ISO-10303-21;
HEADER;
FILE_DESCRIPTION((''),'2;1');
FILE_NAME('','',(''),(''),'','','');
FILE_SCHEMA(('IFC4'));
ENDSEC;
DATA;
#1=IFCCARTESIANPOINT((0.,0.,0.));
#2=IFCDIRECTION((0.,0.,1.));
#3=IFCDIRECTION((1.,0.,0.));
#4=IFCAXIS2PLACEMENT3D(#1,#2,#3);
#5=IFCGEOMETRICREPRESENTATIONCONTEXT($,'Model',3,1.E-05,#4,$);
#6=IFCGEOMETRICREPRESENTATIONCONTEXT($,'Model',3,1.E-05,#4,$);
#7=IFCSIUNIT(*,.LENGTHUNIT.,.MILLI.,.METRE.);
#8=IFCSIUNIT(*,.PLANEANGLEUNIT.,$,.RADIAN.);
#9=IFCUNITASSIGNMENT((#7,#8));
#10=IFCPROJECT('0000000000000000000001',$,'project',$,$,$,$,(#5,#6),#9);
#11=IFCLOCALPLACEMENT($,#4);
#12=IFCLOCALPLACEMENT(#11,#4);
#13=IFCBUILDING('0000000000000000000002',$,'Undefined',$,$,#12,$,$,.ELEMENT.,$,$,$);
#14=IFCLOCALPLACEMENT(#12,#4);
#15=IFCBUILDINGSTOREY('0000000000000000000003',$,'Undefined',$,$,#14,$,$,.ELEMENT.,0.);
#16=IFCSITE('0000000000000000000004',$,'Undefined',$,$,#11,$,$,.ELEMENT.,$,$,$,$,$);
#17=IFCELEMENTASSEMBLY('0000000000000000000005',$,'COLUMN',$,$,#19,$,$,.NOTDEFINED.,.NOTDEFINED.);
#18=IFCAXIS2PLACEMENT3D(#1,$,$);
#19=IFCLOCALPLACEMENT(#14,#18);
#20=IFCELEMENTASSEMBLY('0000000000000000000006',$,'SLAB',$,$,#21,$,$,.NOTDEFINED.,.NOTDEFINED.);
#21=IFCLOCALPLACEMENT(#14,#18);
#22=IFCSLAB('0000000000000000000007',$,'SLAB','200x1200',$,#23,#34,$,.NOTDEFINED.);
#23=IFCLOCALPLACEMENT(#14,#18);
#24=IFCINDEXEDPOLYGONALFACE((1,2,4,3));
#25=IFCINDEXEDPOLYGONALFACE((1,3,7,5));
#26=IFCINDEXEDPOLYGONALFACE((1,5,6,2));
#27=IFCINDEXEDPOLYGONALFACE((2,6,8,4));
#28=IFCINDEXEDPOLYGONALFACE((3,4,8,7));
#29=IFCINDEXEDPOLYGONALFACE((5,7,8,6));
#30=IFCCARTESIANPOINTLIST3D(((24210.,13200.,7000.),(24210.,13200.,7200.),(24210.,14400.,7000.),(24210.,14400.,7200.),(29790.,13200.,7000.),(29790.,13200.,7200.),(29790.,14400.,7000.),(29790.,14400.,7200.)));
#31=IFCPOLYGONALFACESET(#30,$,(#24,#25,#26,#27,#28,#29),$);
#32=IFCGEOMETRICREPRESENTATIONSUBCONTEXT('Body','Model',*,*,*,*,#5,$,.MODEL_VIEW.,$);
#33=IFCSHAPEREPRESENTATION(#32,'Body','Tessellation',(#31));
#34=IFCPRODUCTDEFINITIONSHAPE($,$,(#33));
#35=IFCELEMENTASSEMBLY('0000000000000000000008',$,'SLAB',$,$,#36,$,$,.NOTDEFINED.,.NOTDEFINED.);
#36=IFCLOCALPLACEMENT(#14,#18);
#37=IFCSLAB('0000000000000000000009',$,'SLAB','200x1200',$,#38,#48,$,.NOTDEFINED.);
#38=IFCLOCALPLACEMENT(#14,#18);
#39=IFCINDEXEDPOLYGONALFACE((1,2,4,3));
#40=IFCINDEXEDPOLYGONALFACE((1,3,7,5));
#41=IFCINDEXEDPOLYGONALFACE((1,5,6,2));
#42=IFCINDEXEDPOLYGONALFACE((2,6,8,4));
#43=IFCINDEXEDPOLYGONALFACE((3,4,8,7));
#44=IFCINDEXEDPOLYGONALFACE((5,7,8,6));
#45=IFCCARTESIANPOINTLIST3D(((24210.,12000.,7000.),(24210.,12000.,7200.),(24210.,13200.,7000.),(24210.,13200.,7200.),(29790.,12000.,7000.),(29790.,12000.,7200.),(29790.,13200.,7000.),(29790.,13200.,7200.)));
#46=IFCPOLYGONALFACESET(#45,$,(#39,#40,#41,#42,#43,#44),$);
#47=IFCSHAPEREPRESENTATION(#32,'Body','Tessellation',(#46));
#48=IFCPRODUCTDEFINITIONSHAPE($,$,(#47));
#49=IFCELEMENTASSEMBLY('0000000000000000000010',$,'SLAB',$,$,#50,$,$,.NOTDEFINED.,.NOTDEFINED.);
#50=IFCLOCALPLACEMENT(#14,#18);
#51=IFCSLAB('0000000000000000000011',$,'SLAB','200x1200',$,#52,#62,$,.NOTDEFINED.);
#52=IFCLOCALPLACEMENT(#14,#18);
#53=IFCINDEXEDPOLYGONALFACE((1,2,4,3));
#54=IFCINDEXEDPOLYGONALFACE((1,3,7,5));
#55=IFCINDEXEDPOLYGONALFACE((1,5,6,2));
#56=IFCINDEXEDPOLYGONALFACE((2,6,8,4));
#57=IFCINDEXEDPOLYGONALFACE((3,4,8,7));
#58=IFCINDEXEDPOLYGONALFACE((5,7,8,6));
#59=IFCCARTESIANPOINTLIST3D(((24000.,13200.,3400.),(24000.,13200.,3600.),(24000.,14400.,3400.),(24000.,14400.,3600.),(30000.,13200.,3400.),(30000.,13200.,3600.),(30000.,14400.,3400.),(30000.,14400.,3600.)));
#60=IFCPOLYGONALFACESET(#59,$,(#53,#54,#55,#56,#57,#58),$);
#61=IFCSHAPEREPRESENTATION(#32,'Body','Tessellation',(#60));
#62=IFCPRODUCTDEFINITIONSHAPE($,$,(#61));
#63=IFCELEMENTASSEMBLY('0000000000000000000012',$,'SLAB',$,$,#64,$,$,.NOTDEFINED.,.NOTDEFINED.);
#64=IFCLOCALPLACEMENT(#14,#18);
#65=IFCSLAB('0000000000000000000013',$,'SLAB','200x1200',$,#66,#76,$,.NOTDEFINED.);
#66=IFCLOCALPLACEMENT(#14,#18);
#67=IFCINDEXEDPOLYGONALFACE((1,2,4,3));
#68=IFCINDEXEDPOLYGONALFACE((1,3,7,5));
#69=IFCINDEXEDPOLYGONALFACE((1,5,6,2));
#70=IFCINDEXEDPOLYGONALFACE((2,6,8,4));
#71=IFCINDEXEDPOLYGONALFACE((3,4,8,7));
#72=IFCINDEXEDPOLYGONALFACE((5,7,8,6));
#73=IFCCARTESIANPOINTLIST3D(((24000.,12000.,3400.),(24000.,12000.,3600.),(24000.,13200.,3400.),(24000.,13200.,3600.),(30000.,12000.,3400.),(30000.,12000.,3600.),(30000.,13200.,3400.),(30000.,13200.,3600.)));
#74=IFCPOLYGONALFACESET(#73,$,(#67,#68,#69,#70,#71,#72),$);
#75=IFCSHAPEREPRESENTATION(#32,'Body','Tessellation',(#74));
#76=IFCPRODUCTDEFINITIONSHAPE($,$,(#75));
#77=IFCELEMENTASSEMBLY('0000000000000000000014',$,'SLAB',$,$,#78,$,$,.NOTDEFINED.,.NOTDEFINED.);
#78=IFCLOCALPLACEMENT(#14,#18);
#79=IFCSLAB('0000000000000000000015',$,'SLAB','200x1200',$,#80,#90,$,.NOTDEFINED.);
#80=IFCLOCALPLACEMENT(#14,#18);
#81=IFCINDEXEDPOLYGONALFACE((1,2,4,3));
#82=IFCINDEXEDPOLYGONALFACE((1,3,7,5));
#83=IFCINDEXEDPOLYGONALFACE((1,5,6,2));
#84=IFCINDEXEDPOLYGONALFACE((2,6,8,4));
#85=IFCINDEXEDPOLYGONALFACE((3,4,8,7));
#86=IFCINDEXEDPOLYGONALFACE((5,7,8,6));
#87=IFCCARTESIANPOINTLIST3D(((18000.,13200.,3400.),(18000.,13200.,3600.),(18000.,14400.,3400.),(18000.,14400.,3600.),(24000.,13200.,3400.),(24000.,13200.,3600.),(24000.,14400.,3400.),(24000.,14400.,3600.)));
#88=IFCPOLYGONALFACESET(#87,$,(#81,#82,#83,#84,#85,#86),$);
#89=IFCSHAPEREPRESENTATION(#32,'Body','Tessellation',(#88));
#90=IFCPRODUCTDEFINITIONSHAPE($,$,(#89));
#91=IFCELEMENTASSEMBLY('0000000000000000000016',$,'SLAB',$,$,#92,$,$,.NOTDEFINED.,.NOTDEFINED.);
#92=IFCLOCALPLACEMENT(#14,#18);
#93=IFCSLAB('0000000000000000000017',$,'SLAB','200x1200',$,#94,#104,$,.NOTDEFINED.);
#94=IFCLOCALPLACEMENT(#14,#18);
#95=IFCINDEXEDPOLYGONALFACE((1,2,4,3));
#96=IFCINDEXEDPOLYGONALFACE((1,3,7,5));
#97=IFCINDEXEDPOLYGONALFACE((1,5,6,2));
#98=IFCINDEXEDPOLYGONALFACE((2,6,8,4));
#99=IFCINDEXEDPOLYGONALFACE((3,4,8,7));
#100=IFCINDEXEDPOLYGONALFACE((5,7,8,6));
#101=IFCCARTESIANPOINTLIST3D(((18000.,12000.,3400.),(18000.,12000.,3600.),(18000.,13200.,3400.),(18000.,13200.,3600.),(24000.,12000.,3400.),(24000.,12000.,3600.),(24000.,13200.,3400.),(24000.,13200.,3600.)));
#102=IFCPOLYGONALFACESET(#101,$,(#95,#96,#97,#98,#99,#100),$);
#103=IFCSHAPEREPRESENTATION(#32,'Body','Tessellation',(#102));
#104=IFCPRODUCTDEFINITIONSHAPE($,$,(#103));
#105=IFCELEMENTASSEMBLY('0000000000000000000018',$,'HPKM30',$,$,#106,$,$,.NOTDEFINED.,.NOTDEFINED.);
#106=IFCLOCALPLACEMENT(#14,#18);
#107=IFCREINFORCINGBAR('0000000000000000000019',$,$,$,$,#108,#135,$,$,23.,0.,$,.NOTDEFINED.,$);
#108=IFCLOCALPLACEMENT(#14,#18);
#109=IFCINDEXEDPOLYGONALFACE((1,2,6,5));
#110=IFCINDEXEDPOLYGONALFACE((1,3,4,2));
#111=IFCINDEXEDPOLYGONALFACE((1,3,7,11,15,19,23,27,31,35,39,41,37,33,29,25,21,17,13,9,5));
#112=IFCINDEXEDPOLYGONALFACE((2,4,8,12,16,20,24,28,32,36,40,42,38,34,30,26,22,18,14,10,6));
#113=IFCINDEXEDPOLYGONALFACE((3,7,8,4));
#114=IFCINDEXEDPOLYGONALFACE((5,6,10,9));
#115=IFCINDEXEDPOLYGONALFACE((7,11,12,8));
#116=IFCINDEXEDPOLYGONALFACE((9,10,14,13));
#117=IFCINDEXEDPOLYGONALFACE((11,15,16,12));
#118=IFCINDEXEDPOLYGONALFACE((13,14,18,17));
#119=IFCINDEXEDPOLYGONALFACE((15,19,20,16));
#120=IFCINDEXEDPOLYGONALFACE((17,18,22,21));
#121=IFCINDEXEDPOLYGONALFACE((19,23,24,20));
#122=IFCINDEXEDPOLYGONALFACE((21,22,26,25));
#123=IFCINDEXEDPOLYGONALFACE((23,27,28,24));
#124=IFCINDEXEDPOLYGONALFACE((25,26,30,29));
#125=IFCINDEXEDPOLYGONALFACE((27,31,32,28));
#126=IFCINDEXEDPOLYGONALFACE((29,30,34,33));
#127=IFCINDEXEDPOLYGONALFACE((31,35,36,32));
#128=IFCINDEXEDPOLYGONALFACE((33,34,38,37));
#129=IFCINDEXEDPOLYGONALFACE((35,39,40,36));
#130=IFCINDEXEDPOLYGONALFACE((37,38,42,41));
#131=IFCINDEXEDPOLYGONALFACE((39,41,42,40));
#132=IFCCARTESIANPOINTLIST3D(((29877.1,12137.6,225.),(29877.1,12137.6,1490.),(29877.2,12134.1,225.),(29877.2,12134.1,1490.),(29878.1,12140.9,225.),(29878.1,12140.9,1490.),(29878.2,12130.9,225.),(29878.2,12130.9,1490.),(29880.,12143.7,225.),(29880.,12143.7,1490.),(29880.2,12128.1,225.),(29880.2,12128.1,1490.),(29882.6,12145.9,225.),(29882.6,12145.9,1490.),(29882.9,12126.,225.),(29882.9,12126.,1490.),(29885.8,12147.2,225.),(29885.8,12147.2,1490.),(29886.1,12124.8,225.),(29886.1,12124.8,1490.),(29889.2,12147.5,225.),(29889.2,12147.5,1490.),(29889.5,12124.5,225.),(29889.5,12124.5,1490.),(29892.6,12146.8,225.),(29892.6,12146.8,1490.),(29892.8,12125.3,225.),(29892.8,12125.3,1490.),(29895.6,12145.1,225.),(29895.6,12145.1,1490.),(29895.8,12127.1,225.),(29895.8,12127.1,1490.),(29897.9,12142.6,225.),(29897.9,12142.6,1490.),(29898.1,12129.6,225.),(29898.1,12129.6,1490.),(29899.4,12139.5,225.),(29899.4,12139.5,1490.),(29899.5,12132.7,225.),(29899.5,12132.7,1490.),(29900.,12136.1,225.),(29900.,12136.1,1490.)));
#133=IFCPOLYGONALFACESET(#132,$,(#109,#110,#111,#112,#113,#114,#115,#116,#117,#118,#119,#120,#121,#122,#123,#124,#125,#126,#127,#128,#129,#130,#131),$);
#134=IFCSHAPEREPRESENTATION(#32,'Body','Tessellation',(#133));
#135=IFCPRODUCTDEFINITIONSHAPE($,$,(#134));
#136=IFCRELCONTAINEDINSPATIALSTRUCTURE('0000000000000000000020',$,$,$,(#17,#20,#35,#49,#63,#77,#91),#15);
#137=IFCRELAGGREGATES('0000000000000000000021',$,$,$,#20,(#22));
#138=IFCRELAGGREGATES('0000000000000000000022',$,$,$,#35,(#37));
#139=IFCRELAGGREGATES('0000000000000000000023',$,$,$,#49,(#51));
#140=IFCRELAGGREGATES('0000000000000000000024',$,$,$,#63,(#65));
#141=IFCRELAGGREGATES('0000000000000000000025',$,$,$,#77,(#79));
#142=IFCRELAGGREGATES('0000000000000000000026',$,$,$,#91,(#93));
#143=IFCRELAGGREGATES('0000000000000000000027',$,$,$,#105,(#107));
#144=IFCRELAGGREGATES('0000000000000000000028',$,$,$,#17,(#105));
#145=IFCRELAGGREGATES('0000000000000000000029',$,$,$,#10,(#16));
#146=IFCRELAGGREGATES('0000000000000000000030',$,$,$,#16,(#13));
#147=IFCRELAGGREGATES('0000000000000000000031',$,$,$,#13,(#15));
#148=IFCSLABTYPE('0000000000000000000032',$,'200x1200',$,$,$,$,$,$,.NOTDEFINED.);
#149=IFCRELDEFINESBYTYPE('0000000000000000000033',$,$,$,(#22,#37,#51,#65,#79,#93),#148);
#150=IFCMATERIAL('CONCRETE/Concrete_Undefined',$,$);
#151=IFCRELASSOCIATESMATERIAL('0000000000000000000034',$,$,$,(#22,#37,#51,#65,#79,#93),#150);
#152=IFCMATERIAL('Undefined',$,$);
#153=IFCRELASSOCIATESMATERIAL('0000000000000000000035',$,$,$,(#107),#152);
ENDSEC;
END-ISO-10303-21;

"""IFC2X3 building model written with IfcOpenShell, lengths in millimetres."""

from ifc_helpers import new_model, entity, si_unit, frame, origin_with_axes, place, context, subcontext, project, spatial, polyline, outline, extrude, source, transform, mapped, material, type_object, element, aggregate, save


model = new_model("IFC2X3")

# Units and contexts
model_context_1 = context("Model", 3, precision=1e-05, world=origin_with_axes())
model_context_2 = context("Model", 3, precision=1e-05, world=origin_with_axes())
body_context = subcontext(model_context_1, "Body", "Model", "MODEL_VIEW")
ifc_project = project(units=[si_unit("LENGTHUNIT", "METRE", prefix="MILLI"), si_unit("PLANEANGLEUNIT", "RADIAN")], contexts=[model_context_1, model_context_2])

# Site, building, storey
site_placement = place(None, origin_with_axes())
site = spatial("IfcSite", under=ifc_project, at=site_placement, Name="Undefined", CompositionType="ELEMENT")
building_placement = place(site_placement, origin_with_axes())
building = spatial("IfcBuilding", under=site, at=building_placement, Name="Undefined", CompositionType="ELEMENT")
storey_placement = place(building_placement, origin_with_axes())
storey = spatial("IfcBuildingStorey", under=building, at=storey_placement, Name="Undefined", CompositionType="ELEMENT", Elevation=0.0)

# Shared definitions
ifc_material_1 = material(Name="CONCRETE/Concrete_Undefined")

# Element assembly
assembly_1_placement = place(storey_placement, origin_with_axes())
assembly_1 = element("IfcElementAssembly", 1, at=assembly_1_placement, inside=storey, Name="COLUMN", AssemblyPlace="NOTDEFINED", PredefinedType="NOTDEFINED")

# Element assemblies, slabs
assembly_2_placement = place(storey_placement, origin_with_axes())
assembly_2 = element("IfcElementAssembly", 2, at=assembly_2_placement, inside=storey, Name="SLAB", AssemblyPlace="NOTDEFINED", PredefinedType="NOTDEFINED")
slab_type_1 = type_object("IfcSlabType", Name="200x1200", PredefinedType="NOTDEFINED")
slab_1_placement = place(assembly_2_placement, frame((29790.0, 13200.0, 7100.0), z_axis=(0.0, 0.0, 1.0), x_axis=(0.0, 1.0, 0.0)))
slab_1 = element("IfcSlab", 3, at=slab_1_placement, type_object=slab_type_1, material=ifc_material_1, Name="SLAB", Description="200x1200", PredefinedType="NOTDEFINED", context=body_context, shape_type="SweptSolid", body=[
    extrude(outline(polyline([(0.0, 0.0), (1200.0, 0.0), (1200.0, 5580.0), (0.0, 5580.0), (0.0, 0.0)])), frame((0.0, 0.0, -100.0), z_axis=(0.0, 0.0, 1.0), x_axis=(1.0, 0.0, 0.0)), (0.0, 0.0, 1.0), 200.0),
])
aggregate(assembly_2, [slab_1])
assembly_3_placement = place(storey_placement, origin_with_axes())
assembly_3 = element("IfcElementAssembly", 4, at=assembly_3_placement, inside=storey, Name="SLAB", AssemblyPlace="NOTDEFINED", PredefinedType="NOTDEFINED")
slab_2_placement = place(assembly_3_placement, frame((29790.0, 12000.0, 7100.0), z_axis=(0.0, 0.0, 1.0), x_axis=(0.0, 1.0, 0.0)))
slab_2 = element("IfcSlab", 5, at=slab_2_placement, type_object=slab_type_1, material=ifc_material_1, Name="SLAB", Description="200x1200", PredefinedType="NOTDEFINED", context=body_context, shape_type="SweptSolid", body=[
    extrude(outline(polyline([(0.0, 0.0), (1200.0, 0.0), (1200.0, 5580.0), (0.0, 5580.0), (0.0, 0.0)])), frame((0.0, 0.0, -100.0), z_axis=(0.0, 0.0, 1.0), x_axis=(1.0, 0.0, 0.0)), (0.0, 0.0, 1.0), 200.0),
])
aggregate(assembly_3, [slab_2])
assembly_4_placement = place(storey_placement, origin_with_axes())
assembly_4 = element("IfcElementAssembly", 6, at=assembly_4_placement, inside=storey, Name="SLAB", AssemblyPlace="NOTDEFINED", PredefinedType="NOTDEFINED")
slab_3_placement = place(assembly_4_placement, frame((30000.0, 13200.0, 3500.0), z_axis=(0.0, 0.0, 1.0), x_axis=(0.0, 1.0, 0.0)))
slab_3 = element("IfcSlab", 7, at=slab_3_placement, type_object=slab_type_1, material=ifc_material_1, Name="SLAB", Description="200x1200", PredefinedType="NOTDEFINED", context=body_context, shape_type="SweptSolid", body=[
    extrude(outline(polyline([(0.0, 0.0), (1200.0, 0.0), (1200.0, 6000.0), (0.0, 6000.0), (0.0, 0.0)])), frame((0.0, 0.0, -100.0), z_axis=(0.0, 0.0, 1.0), x_axis=(1.0, 0.0, 0.0)), (0.0, 0.0, 1.0), 200.0),
])
aggregate(assembly_4, [slab_3])
assembly_5_placement = place(storey_placement, origin_with_axes())
assembly_5 = element("IfcElementAssembly", 8, at=assembly_5_placement, inside=storey, Name="SLAB", AssemblyPlace="NOTDEFINED", PredefinedType="NOTDEFINED")
slab_4_placement = place(assembly_5_placement, frame((30000.0, 12000.0, 3500.0), z_axis=(0.0, 0.0, 1.0), x_axis=(0.0, 1.0, 0.0)))
slab_4 = element("IfcSlab", 9, at=slab_4_placement, type_object=slab_type_1, material=ifc_material_1, Name="SLAB", Description="200x1200", PredefinedType="NOTDEFINED", context=body_context, shape_type="SweptSolid", body=[
    extrude(outline(polyline([(0.0, 0.0), (1200.0, 0.0), (1200.0, 6000.0), (0.0, 6000.0), (0.0, 0.0)])), frame((0.0, 0.0, -100.0), z_axis=(0.0, 0.0, 1.0), x_axis=(1.0, 0.0, 0.0)), (0.0, 0.0, 1.0), 200.0),
])
aggregate(assembly_5, [slab_4])
assembly_6_placement = place(storey_placement, origin_with_axes())
assembly_6 = element("IfcElementAssembly", 10, at=assembly_6_placement, inside=storey, Name="SLAB", AssemblyPlace="NOTDEFINED", PredefinedType="NOTDEFINED")
slab_5_placement = place(assembly_6_placement, frame((24000.0, 13200.0, 3500.0), z_axis=(0.0, 0.0, 1.0), x_axis=(0.0, 1.0, 0.0)))
slab_5 = element("IfcSlab", 11, at=slab_5_placement, type_object=slab_type_1, material=ifc_material_1, Name="SLAB", Description="200x1200", PredefinedType="NOTDEFINED", context=body_context, shape_type="SweptSolid", body=[
    extrude(outline(polyline([(0.0, 0.0), (1200.0, 0.0), (1200.0, 6000.0), (0.0, 6000.0), (0.0, 0.0)])), frame((0.0, 0.0, -100.0), z_axis=(0.0, 0.0, 1.0), x_axis=(1.0, 0.0, 0.0)), (0.0, 0.0, 1.0), 200.0),
])
aggregate(assembly_6, [slab_5])
assembly_7_placement = place(storey_placement, origin_with_axes())
assembly_7 = element("IfcElementAssembly", 12, at=assembly_7_placement, inside=storey, Name="SLAB", AssemblyPlace="NOTDEFINED", PredefinedType="NOTDEFINED")
slab_6_placement = place(assembly_7_placement, frame((24000.0, 12000.0, 3500.0), z_axis=(0.0, 0.0, 1.0), x_axis=(0.0, 1.0, 0.0)))
slab_6 = element("IfcSlab", 13, at=slab_6_placement, type_object=slab_type_1, material=ifc_material_1, Name="SLAB", Description="200x1200", PredefinedType="NOTDEFINED", context=body_context, shape_type="SweptSolid", body=[
    extrude(outline(polyline([(0.0, 0.0), (1200.0, 0.0), (1200.0, 6000.0), (0.0, 6000.0), (0.0, 0.0)])), frame((0.0, 0.0, -100.0), z_axis=(0.0, 0.0, 1.0), x_axis=(1.0, 0.0, 0.0)), (0.0, 0.0, 1.0), 200.0),
])
aggregate(assembly_7, [slab_6])

# Shared definitions
ifc_material_2 = material(Name="Undefined")

# Element assembly, reinforcing bar
assembly_8_placement = place(assembly_1_placement, origin_with_axes())
assembly_8 = element("IfcElementAssembly", 14, at=assembly_8_placement, Name="HPKM30", AssemblyPlace="NOTDEFINED", PredefinedType="NOTDEFINED")
shared_shape_1 = source(origin_with_axes(), body_context, "Body", "AdvancedSweptSolid", [
    entity("IfcSweptDiskSolid", entity("IfcTrimmedCurve", entity("IfcLine", entity("IfcCartesianPoint", [0.0, 0.0, 0.0]), entity("IfcVector", entity("IfcDirection", [1.0, 0.0, 0.0]), 1.0)), [entity("IfcParameterValue", 0.0)], [entity("IfcParameterValue", 1265.0)], True, "PARAMETER"), 11.5, None, 0.0, 1265.0),
])
reinforcing_bar_1_placement = place(assembly_8_placement, frame((29888.5, 12136.0, 225.0), z_axis=(0.376627, -0.926365, 0.0), x_axis=(0.0, 0.0, 1.0)))
reinforcing_bar_1 = element("IfcReinforcingBar", 15, at=reinforcing_bar_1_placement, material=ifc_material_2, BarRole="NOTDEFINED", CrossSectionArea=0.0, NominalDiameter=23.0, context=body_context, shape_type="MappedRepresentation", body=[
    mapped(shared_shape_1, transform((0.0, 0.0, 0.0))),
])
aggregate(assembly_8, [reinforcing_bar_1])

aggregate(assembly_1, [assembly_8])

save(model, "model.ifc")
